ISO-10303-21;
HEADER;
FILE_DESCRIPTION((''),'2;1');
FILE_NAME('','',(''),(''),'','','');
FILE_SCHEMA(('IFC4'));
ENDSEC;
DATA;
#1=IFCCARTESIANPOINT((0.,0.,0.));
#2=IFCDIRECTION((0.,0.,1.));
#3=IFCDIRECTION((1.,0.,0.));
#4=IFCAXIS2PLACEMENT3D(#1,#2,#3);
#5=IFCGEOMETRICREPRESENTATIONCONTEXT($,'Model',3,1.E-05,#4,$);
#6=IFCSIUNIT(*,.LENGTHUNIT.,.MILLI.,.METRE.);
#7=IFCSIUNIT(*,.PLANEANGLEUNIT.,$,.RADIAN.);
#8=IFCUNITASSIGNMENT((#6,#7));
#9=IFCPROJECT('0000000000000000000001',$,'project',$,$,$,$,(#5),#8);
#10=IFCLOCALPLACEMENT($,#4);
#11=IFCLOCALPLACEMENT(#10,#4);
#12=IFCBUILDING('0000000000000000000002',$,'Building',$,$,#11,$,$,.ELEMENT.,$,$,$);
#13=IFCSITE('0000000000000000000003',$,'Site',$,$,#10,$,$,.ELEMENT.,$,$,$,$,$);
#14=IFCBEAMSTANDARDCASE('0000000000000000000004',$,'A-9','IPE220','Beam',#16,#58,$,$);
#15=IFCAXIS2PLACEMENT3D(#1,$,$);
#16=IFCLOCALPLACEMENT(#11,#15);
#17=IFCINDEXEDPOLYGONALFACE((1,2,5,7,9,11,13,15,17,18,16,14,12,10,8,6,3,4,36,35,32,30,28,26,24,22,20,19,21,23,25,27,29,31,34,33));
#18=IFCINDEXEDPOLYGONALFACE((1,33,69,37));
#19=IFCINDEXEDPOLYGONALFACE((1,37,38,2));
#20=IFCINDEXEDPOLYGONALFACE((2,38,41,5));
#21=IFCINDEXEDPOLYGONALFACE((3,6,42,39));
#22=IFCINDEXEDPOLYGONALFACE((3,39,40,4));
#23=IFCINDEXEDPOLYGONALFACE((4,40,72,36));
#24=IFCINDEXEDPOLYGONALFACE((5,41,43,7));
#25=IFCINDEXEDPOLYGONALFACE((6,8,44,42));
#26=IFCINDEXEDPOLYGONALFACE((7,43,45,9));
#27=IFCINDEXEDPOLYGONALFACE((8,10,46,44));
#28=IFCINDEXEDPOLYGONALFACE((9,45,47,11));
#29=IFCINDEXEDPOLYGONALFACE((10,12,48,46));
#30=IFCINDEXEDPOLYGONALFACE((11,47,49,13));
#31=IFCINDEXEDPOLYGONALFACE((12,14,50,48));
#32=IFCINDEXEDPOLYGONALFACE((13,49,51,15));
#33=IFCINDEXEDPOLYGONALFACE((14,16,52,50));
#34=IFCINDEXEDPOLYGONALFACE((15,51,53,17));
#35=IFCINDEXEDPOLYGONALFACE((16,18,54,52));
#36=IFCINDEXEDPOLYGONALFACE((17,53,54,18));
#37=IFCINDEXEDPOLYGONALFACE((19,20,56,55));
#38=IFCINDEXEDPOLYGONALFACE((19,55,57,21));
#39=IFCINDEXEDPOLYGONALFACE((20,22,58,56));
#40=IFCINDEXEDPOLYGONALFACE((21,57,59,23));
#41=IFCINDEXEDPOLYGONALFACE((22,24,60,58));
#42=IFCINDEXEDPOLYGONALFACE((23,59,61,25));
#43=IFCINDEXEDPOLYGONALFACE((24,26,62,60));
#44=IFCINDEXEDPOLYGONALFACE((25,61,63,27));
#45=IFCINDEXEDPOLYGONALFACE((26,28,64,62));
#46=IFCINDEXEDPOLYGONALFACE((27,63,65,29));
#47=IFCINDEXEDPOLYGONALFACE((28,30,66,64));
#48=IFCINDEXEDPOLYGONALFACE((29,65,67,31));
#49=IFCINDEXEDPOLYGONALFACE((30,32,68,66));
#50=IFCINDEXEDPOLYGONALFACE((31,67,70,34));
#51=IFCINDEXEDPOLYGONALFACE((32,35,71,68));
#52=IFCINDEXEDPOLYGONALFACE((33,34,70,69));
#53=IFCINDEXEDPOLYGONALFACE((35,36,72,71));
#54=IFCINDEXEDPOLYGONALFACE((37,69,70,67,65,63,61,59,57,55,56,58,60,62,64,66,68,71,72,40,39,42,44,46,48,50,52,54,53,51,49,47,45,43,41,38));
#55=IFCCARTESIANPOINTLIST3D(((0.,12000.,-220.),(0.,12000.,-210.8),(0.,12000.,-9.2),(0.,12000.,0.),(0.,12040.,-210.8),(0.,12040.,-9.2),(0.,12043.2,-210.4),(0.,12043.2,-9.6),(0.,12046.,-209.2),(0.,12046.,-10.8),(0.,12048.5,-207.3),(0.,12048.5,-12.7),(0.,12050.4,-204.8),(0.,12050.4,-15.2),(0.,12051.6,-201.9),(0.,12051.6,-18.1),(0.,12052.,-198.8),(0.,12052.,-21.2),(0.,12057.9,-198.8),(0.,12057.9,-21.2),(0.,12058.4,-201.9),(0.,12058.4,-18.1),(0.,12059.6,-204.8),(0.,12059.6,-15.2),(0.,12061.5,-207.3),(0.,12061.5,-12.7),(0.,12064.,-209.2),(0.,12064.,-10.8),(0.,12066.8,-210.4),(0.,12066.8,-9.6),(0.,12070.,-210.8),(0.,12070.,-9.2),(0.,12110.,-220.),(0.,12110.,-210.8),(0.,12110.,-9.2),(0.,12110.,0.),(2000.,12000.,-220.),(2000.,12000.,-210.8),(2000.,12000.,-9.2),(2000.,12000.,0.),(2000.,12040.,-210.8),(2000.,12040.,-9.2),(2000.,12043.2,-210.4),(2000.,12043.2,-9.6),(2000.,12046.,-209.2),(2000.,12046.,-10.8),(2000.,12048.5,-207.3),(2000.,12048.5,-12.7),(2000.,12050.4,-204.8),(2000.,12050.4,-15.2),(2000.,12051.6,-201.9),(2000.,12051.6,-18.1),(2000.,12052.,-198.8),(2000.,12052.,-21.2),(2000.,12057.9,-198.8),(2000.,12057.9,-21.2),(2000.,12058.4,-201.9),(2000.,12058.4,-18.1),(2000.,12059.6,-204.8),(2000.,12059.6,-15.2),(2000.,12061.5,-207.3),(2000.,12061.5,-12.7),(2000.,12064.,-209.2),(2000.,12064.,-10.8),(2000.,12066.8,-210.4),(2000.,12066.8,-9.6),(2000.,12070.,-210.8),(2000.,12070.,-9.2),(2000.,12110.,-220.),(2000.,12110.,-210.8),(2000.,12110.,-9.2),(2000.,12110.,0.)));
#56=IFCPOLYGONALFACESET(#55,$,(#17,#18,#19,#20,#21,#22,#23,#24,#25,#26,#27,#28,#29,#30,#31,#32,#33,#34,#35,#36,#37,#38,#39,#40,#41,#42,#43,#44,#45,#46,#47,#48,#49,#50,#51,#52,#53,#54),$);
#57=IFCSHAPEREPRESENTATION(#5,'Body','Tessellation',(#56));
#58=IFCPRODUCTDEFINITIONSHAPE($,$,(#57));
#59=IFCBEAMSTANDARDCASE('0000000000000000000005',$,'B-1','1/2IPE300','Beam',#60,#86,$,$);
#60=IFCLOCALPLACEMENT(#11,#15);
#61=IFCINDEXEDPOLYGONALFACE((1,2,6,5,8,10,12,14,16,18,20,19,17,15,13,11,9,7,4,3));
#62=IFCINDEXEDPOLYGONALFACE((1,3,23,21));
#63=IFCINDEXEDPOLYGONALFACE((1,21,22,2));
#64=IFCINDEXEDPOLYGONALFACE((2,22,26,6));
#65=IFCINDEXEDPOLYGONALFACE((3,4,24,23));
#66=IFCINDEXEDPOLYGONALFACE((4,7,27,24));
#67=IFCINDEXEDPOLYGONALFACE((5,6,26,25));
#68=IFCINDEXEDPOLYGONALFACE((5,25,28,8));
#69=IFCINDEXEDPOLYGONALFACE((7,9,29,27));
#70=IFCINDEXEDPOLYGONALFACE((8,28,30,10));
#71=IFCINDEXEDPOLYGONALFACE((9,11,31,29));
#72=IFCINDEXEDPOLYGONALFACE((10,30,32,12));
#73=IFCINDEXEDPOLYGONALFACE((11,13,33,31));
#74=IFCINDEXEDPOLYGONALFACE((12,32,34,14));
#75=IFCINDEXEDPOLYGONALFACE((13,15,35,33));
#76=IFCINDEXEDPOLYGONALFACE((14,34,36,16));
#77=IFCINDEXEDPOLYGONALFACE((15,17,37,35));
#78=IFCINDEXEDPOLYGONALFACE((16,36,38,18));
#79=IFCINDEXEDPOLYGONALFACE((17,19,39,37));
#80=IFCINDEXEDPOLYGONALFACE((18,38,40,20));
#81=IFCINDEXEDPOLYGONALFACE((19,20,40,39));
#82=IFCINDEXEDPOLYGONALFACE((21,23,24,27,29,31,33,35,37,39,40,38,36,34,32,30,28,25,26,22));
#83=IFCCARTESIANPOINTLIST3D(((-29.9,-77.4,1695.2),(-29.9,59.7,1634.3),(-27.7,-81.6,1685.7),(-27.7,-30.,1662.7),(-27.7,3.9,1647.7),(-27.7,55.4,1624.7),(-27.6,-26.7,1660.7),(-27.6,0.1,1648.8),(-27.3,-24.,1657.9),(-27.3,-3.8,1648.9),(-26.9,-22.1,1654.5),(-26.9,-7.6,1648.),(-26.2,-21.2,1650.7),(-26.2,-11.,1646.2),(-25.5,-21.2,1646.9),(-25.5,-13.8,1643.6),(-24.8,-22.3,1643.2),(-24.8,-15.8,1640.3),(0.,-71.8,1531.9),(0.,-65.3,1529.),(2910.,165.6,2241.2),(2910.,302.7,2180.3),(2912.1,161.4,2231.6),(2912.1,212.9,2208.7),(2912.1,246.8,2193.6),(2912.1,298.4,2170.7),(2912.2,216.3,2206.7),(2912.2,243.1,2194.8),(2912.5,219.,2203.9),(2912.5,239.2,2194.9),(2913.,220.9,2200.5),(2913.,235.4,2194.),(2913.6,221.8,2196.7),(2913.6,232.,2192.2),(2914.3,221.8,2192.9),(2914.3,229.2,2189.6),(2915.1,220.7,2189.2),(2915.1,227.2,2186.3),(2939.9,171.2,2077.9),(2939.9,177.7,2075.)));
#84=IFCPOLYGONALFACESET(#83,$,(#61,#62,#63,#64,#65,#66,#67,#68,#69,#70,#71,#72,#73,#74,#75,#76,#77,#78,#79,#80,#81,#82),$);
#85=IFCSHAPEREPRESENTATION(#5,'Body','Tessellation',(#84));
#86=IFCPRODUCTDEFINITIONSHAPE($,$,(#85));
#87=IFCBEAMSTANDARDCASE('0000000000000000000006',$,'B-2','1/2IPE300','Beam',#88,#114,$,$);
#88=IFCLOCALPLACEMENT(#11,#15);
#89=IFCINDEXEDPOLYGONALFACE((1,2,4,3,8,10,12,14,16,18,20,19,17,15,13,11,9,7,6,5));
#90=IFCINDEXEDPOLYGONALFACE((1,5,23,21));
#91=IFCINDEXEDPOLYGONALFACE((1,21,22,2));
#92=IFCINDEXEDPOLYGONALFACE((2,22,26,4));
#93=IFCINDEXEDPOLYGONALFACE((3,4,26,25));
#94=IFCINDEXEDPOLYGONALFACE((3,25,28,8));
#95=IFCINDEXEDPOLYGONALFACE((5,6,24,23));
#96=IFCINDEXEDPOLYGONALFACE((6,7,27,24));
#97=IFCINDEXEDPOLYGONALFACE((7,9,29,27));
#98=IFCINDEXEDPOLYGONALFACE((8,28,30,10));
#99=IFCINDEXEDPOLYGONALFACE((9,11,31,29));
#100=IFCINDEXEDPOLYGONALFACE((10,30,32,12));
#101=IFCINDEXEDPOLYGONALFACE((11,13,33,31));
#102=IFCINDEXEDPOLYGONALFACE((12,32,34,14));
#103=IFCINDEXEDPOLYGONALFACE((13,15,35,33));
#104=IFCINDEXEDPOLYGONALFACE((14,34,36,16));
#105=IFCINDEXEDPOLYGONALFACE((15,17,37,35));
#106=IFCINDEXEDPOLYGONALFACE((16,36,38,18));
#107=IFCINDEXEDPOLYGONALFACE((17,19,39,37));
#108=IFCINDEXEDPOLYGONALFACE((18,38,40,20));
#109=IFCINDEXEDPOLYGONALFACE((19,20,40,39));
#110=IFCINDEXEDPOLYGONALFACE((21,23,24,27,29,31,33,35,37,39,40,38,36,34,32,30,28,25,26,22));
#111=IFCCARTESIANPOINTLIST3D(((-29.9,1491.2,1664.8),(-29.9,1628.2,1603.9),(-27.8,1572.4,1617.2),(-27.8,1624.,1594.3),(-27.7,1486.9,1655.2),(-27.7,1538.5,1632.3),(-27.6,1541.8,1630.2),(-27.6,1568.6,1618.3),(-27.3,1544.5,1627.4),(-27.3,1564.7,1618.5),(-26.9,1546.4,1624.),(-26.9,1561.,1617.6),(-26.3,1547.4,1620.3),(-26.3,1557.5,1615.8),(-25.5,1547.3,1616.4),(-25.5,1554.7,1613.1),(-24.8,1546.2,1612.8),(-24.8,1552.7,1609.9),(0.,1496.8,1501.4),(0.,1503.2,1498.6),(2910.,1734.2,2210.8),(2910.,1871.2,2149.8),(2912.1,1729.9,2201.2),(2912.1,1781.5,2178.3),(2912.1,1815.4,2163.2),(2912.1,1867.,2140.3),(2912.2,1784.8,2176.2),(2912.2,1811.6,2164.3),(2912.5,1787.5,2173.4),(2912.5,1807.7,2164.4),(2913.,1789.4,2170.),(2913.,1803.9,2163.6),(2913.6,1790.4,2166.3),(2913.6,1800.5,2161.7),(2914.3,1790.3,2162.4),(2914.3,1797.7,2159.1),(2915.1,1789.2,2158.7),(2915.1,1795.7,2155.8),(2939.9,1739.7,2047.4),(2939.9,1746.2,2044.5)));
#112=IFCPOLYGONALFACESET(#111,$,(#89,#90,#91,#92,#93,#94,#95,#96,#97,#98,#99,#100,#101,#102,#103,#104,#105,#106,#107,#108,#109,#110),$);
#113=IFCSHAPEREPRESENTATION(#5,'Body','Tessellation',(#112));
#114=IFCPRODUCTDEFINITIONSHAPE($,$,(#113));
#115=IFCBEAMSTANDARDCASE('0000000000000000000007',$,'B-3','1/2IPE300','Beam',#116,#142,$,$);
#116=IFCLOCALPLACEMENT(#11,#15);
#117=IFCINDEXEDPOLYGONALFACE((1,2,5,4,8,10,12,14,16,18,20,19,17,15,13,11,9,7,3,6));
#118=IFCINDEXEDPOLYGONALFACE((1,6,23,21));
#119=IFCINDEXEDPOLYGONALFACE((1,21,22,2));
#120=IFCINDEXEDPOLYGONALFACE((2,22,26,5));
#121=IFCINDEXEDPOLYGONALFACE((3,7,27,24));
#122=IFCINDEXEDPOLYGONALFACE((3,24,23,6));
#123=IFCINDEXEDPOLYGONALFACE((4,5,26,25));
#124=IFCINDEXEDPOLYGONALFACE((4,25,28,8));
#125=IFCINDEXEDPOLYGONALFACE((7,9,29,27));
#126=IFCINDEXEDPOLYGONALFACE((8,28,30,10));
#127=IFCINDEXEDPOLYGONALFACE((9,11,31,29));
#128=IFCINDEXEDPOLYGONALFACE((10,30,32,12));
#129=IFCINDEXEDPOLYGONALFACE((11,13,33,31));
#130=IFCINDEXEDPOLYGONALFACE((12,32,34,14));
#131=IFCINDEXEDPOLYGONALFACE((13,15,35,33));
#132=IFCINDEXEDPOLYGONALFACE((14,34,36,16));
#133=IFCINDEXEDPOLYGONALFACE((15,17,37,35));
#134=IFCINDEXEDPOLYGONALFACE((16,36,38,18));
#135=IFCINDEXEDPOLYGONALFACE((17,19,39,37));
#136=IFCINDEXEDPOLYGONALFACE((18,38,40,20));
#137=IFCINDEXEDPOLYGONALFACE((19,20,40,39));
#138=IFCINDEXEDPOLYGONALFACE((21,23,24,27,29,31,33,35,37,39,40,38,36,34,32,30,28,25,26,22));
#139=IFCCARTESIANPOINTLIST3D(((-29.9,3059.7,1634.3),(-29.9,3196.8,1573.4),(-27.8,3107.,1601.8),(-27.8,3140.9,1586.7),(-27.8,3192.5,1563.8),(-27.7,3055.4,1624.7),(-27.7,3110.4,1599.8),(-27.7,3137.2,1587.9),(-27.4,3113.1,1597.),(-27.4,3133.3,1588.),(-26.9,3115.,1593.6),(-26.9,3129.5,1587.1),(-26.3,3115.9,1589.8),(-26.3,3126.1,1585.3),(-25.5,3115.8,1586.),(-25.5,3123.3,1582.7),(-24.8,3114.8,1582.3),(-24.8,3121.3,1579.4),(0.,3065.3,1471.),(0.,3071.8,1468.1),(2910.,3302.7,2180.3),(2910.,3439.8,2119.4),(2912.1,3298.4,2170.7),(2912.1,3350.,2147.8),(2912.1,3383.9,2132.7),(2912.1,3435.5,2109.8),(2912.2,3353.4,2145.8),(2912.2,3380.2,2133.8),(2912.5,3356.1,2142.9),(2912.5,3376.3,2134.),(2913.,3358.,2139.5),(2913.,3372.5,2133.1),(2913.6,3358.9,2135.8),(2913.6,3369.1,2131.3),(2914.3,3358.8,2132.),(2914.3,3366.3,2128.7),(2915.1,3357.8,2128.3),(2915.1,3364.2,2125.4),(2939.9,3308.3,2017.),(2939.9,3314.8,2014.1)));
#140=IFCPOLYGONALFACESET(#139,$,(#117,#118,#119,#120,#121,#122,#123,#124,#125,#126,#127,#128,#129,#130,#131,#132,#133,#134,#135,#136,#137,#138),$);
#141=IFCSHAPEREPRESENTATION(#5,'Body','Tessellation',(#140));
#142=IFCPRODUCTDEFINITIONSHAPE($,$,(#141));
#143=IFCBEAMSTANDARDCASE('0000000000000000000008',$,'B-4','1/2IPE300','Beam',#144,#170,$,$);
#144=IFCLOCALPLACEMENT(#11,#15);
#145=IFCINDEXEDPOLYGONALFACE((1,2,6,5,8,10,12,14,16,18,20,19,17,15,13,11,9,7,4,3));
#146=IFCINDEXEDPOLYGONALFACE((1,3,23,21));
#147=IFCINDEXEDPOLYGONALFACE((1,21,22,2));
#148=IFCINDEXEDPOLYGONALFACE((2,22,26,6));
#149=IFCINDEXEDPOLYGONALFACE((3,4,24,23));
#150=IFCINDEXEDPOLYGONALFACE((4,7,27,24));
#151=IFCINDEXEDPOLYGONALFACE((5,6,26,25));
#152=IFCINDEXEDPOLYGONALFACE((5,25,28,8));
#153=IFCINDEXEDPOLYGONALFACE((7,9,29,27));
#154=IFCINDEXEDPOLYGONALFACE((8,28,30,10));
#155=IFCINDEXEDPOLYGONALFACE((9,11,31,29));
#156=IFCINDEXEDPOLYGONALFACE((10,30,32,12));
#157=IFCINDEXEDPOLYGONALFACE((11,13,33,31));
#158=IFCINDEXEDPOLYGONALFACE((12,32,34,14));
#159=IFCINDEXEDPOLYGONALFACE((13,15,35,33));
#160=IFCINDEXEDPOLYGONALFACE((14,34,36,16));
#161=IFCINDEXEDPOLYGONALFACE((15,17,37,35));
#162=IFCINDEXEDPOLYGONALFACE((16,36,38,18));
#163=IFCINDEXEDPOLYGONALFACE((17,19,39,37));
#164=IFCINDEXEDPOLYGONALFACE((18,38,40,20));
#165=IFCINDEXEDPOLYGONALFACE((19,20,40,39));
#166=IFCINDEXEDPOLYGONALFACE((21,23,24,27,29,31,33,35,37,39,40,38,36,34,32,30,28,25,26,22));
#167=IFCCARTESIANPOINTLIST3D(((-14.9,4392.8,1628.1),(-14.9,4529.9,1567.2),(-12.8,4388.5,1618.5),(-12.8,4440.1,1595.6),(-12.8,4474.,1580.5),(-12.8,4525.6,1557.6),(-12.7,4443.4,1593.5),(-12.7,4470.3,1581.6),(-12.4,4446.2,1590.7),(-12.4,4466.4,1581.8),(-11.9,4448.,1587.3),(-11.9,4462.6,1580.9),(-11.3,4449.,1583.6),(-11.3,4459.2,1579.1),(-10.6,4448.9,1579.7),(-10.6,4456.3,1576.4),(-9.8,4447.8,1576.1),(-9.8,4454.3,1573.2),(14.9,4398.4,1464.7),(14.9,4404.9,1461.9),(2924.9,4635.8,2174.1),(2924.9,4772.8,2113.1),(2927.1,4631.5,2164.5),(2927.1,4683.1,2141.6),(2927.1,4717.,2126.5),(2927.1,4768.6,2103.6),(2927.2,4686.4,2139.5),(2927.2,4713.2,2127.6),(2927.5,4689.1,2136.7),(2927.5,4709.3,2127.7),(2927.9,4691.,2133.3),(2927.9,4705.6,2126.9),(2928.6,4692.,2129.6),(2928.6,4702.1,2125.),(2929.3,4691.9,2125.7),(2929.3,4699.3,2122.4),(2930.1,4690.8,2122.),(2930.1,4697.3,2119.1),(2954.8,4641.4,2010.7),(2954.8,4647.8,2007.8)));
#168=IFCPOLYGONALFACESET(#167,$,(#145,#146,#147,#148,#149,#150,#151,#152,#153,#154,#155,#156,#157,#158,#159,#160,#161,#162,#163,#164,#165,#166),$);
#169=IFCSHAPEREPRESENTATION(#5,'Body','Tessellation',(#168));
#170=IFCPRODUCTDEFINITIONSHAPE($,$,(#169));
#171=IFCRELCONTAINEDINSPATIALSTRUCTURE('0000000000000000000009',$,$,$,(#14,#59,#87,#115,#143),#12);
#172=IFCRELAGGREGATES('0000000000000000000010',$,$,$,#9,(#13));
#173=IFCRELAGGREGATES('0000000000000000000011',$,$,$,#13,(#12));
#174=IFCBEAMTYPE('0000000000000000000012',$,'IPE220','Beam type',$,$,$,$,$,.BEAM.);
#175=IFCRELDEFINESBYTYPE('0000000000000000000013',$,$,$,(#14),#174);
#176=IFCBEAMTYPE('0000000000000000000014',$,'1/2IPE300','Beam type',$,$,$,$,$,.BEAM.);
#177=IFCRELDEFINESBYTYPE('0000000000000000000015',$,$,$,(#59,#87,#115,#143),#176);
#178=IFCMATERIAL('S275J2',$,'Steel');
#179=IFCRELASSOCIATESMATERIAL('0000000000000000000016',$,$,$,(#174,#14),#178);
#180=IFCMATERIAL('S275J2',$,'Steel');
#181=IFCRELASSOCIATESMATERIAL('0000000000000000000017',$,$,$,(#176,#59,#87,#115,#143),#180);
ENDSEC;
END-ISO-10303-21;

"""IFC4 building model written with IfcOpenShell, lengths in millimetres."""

from ifc_helpers import new_model, si_unit, frame, origin_with_axes, place, context, project, spatial, i_section, t_section, extrude, material, material_profile, profile_set, profile_usage, type_object, element, save


model = new_model("IFC4")

# Units and contexts
model_context = context("Model", 3, precision=1e-05, world=origin_with_axes())
ifc_project = project(units=[si_unit("LENGTHUNIT", "METRE", prefix="MILLI"), si_unit("PLANEANGLEUNIT", "RADIAN")], contexts=[model_context])

# Site, building
site_placement = place(None, origin_with_axes())
site = spatial("IfcSite", under=ifc_project, at=site_placement, Name="Site", CompositionType="ELEMENT")
building_placement = place(site_placement, origin_with_axes())
building = spatial("IfcBuilding", under=site, at=building_placement, Name="Building", CompositionType="ELEMENT")

# Beams
ifc_material_1 = material(Name="S275J2", Category="Steel")
ifc_material_profile_1 = material_profile(ifc_material_1, i_section(OverallWidth=110.0, OverallDepth=220.0, WebThickness=5.9, FlangeThickness=9.2, FilletRadius=12.0), Name="IPE220")
ifc_profile_set_1 = profile_set([ifc_material_profile_1])
beam_type_1 = type_object("IfcBeamType", Name="IPE220", Description="Beam type", PredefinedType="BEAM", material=ifc_profile_set_1)
ifc_profile_usage_1 = profile_usage(ifc_profile_set_1, cardinal=9)
beam_1_placement = place(building_placement, frame((0.0, 12000.0, 0.0), z_axis=(1.0, 0.0, 0.0), x_axis=(0.0, 1.0, 0.0)))
element("IfcBeamStandardCase", 1, at=beam_1_placement, inside=building, type_object=beam_type_1, material=ifc_profile_usage_1, Name="A-9", Description="IPE220", ObjectType="Beam", context=model_context, shape_type="SweptSolid", body=[
    extrude(i_section(OverallWidth=110.0, OverallDepth=220.0, WebThickness=5.9, FlangeThickness=9.2, FilletRadius=12.0), frame((55.0, -110.0, 0.0)), (0.0, 0.0, 1.0), 2000.0),
])
ifc_material_2 = material(Name="S275J2", Category="Steel")
ifc_material_profile_2 = material_profile(ifc_material_2, t_section(Depth=150.0, FlangeWidth=150.0, WebThickness=7.1, FlangeThickness=10.7, FilletRadius=15.0), Name="1/2IPE300")
ifc_profile_set_2 = profile_set([ifc_material_profile_2])
ifc_profile_usage_2 = profile_usage(ifc_profile_set_2, cardinal=1)
beam_type_2 = type_object("IfcBeamType", Name="1/2IPE300", Description="Beam type", PredefinedType="BEAM", material=ifc_profile_set_2)
beam_2_placement = place(building_placement, frame((0.0, 0.0, 1500.0), z_axis=(0.98, 0.081, 0.182), x_axis=(-0.0001, 0.9138, -0.40616)))
element("IfcBeamStandardCase", 2, at=beam_2_placement, inside=building, type_object=beam_type_2, material=ifc_profile_usage_2, Name="B-1", Description="1/2IPE300", ObjectType="Beam", context=model_context, shape_type="SweptSolid", body=[
    extrude(t_section(Depth=150.0, FlangeWidth=150.0, WebThickness=7.1, FlangeThickness=10.7, FilletRadius=15.0), frame((-75.0, 75.0, 0.0)), (0.0, 0.0, 1.0), 3000.0),
])
ifc_profile_usage_3 = profile_usage(ifc_profile_set_2, cardinal=2)
beam_3_placement = place(building_placement, frame((0.0, 1500.0, 1500.0), z_axis=(0.98, 0.081, 0.182), x_axis=(-0.0001, 0.9138, -0.40616)))
element("IfcBeamStandardCase", 3, at=beam_3_placement, inside=building, type_object=beam_type_2, material=ifc_profile_usage_3, Name="B-2", Description="1/2IPE300", ObjectType="Beam", context=model_context, shape_type="SweptSolid", body=[
    extrude(t_section(Depth=150.0, FlangeWidth=150.0, WebThickness=7.1, FlangeThickness=10.7, FilletRadius=15.0), frame((0.0, 75.0, 0.0)), (0.0, 0.0, 1.0), 3000.0),
])
ifc_profile_usage_4 = profile_usage(ifc_profile_set_2, cardinal=3)
beam_4_placement = place(building_placement, frame((0.0, 3000.0, 1500.0), z_axis=(0.98, 0.081, 0.182), x_axis=(-0.0001, 0.9138, -0.40616)))
element("IfcBeamStandardCase", 4, at=beam_4_placement, inside=building, type_object=beam_type_2, material=ifc_profile_usage_4, Name="B-3", Description="1/2IPE300", ObjectType="Beam", context=model_context, shape_type="SweptSolid", body=[
    extrude(t_section(Depth=150.0, FlangeWidth=150.0, WebThickness=7.1, FlangeThickness=10.7, FilletRadius=15.0), frame((75.0, 75.0, 0.0)), (0.0, 0.0, 1.0), 3000.0),
])
ifc_profile_usage_5 = profile_usage(ifc_profile_set_2, cardinal=4)
beam_5_placement = place(building_placement, frame((0.0, 4500.0, 1500.0), z_axis=(0.98, 0.081, 0.182), x_axis=(-0.0001, 0.9138, -0.40616)))
element("IfcBeamStandardCase", 5, at=beam_5_placement, inside=building, type_object=beam_type_2, material=ifc_profile_usage_5, Name="B-4", Description="1/2IPE300", ObjectType="Beam", context=model_context, shape_type="SweptSolid", body=[
    extrude(t_section(Depth=150.0, FlangeWidth=150.0, WebThickness=7.1, FlangeThickness=10.7, FilletRadius=15.0), frame((-75.0, 0.0, 0.0)), (0.0, 0.0, 1.0), 3000.0),
])

save(model, "model.ifc")
